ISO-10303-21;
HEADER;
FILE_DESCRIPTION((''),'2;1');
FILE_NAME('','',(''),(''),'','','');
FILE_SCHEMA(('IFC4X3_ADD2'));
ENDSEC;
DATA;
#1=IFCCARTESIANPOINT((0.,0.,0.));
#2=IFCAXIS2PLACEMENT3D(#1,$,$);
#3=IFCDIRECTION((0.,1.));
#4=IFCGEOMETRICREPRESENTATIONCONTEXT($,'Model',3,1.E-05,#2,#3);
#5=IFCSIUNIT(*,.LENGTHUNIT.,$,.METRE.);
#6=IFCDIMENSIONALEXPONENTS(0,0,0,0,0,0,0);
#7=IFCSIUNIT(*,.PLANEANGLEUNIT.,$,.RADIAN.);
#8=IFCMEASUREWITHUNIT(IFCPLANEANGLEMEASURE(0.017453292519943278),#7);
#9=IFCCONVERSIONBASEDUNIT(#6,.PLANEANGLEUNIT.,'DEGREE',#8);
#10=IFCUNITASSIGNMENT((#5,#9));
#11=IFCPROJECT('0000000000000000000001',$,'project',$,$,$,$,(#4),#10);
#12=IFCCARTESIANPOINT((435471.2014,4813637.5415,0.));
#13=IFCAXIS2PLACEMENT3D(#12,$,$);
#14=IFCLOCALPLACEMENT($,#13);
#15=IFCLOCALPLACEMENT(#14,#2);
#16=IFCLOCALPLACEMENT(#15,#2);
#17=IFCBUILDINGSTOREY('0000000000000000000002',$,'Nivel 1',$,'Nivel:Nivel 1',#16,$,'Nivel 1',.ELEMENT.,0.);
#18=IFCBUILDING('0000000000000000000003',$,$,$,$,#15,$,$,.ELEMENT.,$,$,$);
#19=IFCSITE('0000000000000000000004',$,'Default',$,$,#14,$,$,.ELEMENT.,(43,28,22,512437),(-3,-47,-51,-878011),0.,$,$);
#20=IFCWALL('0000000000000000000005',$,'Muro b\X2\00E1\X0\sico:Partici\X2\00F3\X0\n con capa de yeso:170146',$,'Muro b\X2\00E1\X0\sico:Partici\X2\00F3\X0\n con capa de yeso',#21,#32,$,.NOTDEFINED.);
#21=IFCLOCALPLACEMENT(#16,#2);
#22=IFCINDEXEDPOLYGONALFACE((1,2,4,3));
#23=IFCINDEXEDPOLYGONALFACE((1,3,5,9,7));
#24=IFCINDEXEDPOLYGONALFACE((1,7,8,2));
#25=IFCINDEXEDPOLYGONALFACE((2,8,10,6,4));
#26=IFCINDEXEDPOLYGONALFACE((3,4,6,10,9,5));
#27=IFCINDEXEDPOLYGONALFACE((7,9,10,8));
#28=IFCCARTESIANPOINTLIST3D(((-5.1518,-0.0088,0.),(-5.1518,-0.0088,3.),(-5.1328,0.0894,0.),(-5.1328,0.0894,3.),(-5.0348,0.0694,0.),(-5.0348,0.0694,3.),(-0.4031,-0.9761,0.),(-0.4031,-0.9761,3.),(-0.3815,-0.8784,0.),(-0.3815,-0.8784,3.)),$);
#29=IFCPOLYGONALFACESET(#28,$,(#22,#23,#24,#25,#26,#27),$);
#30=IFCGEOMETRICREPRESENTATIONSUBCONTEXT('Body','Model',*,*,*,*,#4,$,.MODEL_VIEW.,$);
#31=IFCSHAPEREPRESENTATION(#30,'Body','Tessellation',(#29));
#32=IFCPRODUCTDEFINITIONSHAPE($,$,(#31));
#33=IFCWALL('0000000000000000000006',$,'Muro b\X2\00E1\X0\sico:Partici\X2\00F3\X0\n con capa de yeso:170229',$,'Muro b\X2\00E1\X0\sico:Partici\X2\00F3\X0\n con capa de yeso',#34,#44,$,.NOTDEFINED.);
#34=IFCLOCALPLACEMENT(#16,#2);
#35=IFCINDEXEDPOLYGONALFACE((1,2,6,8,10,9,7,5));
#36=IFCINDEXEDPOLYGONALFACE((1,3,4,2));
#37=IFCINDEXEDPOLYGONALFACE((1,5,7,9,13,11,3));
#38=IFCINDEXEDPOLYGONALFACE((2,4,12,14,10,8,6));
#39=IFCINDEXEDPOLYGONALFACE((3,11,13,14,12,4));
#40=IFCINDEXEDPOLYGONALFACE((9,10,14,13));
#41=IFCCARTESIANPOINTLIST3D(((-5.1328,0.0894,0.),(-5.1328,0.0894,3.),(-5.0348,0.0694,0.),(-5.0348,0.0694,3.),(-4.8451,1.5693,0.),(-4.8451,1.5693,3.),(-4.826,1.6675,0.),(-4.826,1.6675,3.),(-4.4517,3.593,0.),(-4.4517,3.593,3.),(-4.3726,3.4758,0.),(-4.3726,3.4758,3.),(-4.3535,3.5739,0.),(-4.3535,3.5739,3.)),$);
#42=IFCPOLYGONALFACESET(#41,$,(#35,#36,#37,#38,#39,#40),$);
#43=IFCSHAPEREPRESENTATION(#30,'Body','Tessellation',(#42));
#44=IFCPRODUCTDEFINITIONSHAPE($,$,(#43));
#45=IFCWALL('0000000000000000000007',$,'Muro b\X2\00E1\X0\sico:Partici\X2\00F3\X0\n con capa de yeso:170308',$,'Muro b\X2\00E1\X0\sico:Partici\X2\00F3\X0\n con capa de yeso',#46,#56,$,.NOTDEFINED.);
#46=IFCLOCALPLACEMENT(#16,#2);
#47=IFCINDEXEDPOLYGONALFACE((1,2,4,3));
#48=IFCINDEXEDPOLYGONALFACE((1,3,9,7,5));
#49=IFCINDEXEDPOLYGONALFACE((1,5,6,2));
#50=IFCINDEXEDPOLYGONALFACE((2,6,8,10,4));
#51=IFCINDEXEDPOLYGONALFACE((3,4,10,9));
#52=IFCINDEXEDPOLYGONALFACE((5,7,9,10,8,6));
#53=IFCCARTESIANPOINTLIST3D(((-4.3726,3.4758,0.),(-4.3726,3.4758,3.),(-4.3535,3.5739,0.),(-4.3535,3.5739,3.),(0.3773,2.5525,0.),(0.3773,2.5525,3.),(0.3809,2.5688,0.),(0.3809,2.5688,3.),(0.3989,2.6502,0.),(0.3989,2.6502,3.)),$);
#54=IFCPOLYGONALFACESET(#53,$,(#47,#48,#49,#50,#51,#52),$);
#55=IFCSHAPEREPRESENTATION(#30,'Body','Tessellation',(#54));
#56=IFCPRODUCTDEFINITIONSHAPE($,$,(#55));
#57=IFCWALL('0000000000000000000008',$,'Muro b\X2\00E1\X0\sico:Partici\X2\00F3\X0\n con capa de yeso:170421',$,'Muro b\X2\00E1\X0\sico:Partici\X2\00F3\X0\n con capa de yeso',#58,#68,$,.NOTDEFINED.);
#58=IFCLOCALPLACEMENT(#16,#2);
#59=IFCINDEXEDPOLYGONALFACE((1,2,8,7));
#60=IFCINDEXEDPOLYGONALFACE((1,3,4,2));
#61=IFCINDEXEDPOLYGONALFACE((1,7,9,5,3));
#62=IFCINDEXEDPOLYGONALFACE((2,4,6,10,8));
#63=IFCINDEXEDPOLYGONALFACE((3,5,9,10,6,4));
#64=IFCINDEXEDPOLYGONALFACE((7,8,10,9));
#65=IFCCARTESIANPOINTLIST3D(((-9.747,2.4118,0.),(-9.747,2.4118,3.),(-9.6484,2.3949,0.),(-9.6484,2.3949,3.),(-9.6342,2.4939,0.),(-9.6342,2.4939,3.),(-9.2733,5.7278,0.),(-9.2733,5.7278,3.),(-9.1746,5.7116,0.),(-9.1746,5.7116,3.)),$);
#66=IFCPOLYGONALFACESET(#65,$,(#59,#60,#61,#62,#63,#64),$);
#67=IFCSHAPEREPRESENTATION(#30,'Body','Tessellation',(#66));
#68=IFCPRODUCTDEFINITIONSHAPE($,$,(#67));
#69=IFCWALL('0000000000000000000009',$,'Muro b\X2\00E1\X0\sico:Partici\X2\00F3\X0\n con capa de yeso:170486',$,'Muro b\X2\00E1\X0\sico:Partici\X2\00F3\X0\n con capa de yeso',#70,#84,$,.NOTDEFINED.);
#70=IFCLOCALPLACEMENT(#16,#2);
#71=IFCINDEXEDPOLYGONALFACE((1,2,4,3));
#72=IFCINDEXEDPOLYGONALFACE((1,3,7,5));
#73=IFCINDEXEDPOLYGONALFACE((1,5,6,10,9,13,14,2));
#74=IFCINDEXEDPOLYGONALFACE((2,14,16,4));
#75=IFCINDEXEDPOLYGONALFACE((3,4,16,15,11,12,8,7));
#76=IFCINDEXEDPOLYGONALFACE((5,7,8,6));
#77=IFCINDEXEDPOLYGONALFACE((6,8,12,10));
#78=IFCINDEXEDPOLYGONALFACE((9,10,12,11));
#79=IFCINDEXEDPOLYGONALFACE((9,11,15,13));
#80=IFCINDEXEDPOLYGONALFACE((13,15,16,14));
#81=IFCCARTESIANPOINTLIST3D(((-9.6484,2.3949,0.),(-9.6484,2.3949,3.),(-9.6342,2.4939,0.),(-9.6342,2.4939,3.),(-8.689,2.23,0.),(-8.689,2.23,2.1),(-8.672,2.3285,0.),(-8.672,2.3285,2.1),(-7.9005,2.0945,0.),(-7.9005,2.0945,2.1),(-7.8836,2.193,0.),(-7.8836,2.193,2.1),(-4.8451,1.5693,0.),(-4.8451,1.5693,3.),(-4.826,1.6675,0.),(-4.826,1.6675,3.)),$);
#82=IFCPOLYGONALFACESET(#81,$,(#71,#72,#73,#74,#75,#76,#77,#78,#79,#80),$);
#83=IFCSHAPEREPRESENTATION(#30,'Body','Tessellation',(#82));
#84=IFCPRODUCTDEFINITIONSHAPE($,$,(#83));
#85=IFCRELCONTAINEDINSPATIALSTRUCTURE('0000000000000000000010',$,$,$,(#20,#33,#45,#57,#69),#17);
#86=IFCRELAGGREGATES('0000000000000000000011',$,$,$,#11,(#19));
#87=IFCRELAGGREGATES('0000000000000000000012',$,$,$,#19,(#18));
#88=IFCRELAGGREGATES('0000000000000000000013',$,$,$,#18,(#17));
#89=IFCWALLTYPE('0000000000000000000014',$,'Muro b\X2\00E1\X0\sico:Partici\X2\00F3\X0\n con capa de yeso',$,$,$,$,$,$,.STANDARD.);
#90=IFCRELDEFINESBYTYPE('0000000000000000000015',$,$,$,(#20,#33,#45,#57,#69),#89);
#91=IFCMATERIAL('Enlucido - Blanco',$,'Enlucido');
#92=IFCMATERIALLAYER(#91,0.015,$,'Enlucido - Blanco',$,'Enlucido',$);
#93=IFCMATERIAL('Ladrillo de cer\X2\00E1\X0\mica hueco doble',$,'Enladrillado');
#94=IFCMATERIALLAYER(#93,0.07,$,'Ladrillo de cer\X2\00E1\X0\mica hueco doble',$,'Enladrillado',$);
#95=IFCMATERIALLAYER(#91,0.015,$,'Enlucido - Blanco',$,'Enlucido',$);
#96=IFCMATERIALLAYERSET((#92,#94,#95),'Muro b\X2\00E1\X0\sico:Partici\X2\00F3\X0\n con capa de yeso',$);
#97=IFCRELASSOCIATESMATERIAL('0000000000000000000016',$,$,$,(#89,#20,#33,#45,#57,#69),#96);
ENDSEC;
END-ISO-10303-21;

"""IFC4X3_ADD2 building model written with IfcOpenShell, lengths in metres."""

from ifc_helpers import new_model, entity, si_unit, converted_unit, direction, frame, frame_2d, origin, place, context, subcontext, project, spatial, polyline, rectangle, outline, extrude, material, layer, layer_set, type_object, element, save


model = new_model("IFC4X3_ADD2")

# Units and contexts
model_context = context("Model", 3, precision=1e-05, world=origin(), true_north=direction((0.0, 1.0)))
body_context = subcontext(model_context, "Body", "Model", "MODEL_VIEW")
ifc_project = project(units=[si_unit("LENGTHUNIT", "METRE"), converted_unit("PLANEANGLEUNIT", "DEGREE", entity("IfcPlaneAngleMeasure", 0.017453292519943278), si_unit("PLANEANGLEUNIT", "RADIAN"), dimensions=[0, 0, 0, 0, 0, 0, 0])], contexts=[model_context])

# Site, building, storey
site_placement = place(None, frame((435471.2014, 4813637.5415, 0.0)))
site = spatial("IfcSite", under=ifc_project, at=site_placement, Name="Default", CompositionType="ELEMENT", RefLatitude=(43, 28, 22, 512437), RefLongitude=(-3, -47, -51, -878011), RefElevation=0.0)
building_placement = place(site_placement, origin())
building = spatial("IfcBuilding", under=site, at=building_placement, CompositionType="ELEMENT")
storey_placement = place(building_placement, origin())
storey = spatial("IfcBuildingStorey", under=building, at=storey_placement, Name="Nivel 1", ObjectType="Nivel:Nivel 1", LongName="Nivel 1", CompositionType="ELEMENT", Elevation=0.0)

# Shared definitions
ifc_material_1 = material(Name="Enlucido - Blanco", Category="Enlucido")
ifc_layer_1 = layer(ifc_material_1, 0.015, Name="Enlucido - Blanco", Category="Enlucido")
ifc_material_2 = material(Name="Ladrillo de cerámica hueco doble", Category="Enladrillado")
ifc_layer_2 = layer(ifc_material_2, 0.07, Name="Ladrillo de cerámica hueco doble", Category="Enladrillado")
ifc_layer_3 = layer(ifc_material_1, 0.015, Name="Enlucido - Blanco", Category="Enlucido")
ifc_layer_set_1 = layer_set([ifc_layer_1, ifc_layer_2, ifc_layer_3], Name="Muro básico:Partición con capa de yeso")
wall_type_1 = type_object("IfcWallType", Name="Muro básico:Partición con capa de yeso", PredefinedType="STANDARD", material=ifc_layer_set_1)

# Walls
wall_1_placement = place(storey_placement, frame((-0.3915, -0.9274, 0.0), z_axis=(0.0, 0.0, 1.0), x_axis=(-0.979879, 0.199592, 0.0)))
element("IfcWall", 1, at=wall_1_placement, inside=storey, type_object=wall_type_1, material=ifc_layer_set_1, Name="Muro básico:Partición con capa de yeso:170146", ObjectType="Muro básico:Partición con capa de yeso", PredefinedType="NOTDEFINED", context=body_context, shape_type="SweptSolid", body=[
    extrude(outline(polyline([(4.8488, -0.05), (4.8479, 0.05), (0.0017, 0.05), (0.0, -0.05), (4.7488, -0.05), (4.8488, -0.05)])), origin(), (0.0, 0.0, 1.0), 3.0),
])
wall_2_placement = place(storey_placement, frame((-5.0838, 0.0789, 0.0), z_axis=(0.0, 0.0, 1.0), x_axis=(0.190809, 0.981627, 0.0)))
element("IfcWall", 2, at=wall_2_placement, inside=storey, type_object=wall_type_1, material=ifc_layer_set_1, Name="Muro básico:Partición con capa de yeso:170229", ObjectType="Muro básico:Partición con capa de yeso", PredefinedType="NOTDEFINED", context=body_context, shape_type="SweptSolid", body=[
    extrude(outline(polyline([(3.5701, -0.05), (3.5701, 0.05), (1.6086, 0.05), (1.5086, 0.05), (0.0009, 0.05), (0.0, -0.05), (3.4701, -0.05), (3.5701, -0.05)])), origin(), (0.0, 0.0, 1.0), 3.0),
])
wall_3_placement = place(storey_placement, frame((-4.3631, 3.5249, 0.0), z_axis=(0.0, 0.0, 1.0), x_axis=(0.981627, -0.190809, 0.0)))
element("IfcWall", 3, at=wall_3_placement, inside=storey, type_object=wall_type_1, material=ifc_layer_set_1, Name="Muro básico:Partición con capa de yeso:170308", ObjectType="Muro básico:Partición con capa de yeso", PredefinedType="NOTDEFINED", context=body_context, shape_type="SweptSolid", body=[
    extrude(outline(polyline([(4.8388, -0.05), (4.8392, -0.0333), (4.8414, 0.05), (0.0, 0.05), (0.0, -0.05), (4.8388, -0.05)])), origin(), (0.0, 0.0, 1.0), 3.0),
])
wall_4_placement = place(storey_placement, frame((-9.2238, 5.7207, 0.0), z_axis=(0.0, 0.0, 1.0), x_axis=(-0.141418, -0.98995, 0.0)))
element("IfcWall", 4, at=wall_4_placement, inside=storey, type_object=wall_type_1, material=ifc_layer_set_1, Name="Muro básico:Partición con capa de yeso:170421", ObjectType="Muro básico:Partición con capa de yeso", PredefinedType="NOTDEFINED", context=body_context, shape_type="SweptSolid", body=[
    extrude(outline(polyline([(3.3496, -0.05), (3.3524, 0.05), (3.2524, 0.05), (0.002, 0.05), (0.0, -0.05), (3.3496, -0.05)])), origin(), (0.0, 0.0, 1.0), 3.0),
])

# Wall, opening
wall_5_placement = place(storey_placement, frame((-9.6427, 2.4446, 0.0), z_axis=(0.0, 0.0, 1.0), x_axis=(0.98555, -0.169385, 0.0)))
wall_5 = element("IfcWall", 5, at=wall_5_placement, inside=storey, type_object=wall_type_1, material=ifc_layer_set_1, Name="Muro básico:Partición con capa de yeso:170486", ObjectType="Muro básico:Partición con capa de yeso", PredefinedType="NOTDEFINED", context=body_context, shape_type="SweptSolid", body=[
    extrude(outline(polyline([(0.0028, -0.05), (4.8766, -0.05), (4.8787, 0.05), (0.0, 0.05), (0.0028, -0.05)])), origin(), (0.0, 0.0, 1.0), 3.0),
])
opening_1_placement = place(wall_5_placement, frame((1.7763, 0.05, 0.0)))
element("IfcOpeningElement", 6, at=opening_1_placement, cuts=wall_5, PredefinedType="OPENING", context=body_context, shape_type="SweptSolid", body=[
    extrude(rectangle(XDim=2.1, YDim=0.8, at=frame_2d((1.05, 0.4), x_axis=(1.0, 0.0))), frame((0.0, 0.0, 0.0), z_axis=(0.0, -1.0, 0.0), x_axis=(0.0, 0.0, 1.0)), (0.0, 0.0, 1.0), 0.1),
])

save(model, "model.ifc")
